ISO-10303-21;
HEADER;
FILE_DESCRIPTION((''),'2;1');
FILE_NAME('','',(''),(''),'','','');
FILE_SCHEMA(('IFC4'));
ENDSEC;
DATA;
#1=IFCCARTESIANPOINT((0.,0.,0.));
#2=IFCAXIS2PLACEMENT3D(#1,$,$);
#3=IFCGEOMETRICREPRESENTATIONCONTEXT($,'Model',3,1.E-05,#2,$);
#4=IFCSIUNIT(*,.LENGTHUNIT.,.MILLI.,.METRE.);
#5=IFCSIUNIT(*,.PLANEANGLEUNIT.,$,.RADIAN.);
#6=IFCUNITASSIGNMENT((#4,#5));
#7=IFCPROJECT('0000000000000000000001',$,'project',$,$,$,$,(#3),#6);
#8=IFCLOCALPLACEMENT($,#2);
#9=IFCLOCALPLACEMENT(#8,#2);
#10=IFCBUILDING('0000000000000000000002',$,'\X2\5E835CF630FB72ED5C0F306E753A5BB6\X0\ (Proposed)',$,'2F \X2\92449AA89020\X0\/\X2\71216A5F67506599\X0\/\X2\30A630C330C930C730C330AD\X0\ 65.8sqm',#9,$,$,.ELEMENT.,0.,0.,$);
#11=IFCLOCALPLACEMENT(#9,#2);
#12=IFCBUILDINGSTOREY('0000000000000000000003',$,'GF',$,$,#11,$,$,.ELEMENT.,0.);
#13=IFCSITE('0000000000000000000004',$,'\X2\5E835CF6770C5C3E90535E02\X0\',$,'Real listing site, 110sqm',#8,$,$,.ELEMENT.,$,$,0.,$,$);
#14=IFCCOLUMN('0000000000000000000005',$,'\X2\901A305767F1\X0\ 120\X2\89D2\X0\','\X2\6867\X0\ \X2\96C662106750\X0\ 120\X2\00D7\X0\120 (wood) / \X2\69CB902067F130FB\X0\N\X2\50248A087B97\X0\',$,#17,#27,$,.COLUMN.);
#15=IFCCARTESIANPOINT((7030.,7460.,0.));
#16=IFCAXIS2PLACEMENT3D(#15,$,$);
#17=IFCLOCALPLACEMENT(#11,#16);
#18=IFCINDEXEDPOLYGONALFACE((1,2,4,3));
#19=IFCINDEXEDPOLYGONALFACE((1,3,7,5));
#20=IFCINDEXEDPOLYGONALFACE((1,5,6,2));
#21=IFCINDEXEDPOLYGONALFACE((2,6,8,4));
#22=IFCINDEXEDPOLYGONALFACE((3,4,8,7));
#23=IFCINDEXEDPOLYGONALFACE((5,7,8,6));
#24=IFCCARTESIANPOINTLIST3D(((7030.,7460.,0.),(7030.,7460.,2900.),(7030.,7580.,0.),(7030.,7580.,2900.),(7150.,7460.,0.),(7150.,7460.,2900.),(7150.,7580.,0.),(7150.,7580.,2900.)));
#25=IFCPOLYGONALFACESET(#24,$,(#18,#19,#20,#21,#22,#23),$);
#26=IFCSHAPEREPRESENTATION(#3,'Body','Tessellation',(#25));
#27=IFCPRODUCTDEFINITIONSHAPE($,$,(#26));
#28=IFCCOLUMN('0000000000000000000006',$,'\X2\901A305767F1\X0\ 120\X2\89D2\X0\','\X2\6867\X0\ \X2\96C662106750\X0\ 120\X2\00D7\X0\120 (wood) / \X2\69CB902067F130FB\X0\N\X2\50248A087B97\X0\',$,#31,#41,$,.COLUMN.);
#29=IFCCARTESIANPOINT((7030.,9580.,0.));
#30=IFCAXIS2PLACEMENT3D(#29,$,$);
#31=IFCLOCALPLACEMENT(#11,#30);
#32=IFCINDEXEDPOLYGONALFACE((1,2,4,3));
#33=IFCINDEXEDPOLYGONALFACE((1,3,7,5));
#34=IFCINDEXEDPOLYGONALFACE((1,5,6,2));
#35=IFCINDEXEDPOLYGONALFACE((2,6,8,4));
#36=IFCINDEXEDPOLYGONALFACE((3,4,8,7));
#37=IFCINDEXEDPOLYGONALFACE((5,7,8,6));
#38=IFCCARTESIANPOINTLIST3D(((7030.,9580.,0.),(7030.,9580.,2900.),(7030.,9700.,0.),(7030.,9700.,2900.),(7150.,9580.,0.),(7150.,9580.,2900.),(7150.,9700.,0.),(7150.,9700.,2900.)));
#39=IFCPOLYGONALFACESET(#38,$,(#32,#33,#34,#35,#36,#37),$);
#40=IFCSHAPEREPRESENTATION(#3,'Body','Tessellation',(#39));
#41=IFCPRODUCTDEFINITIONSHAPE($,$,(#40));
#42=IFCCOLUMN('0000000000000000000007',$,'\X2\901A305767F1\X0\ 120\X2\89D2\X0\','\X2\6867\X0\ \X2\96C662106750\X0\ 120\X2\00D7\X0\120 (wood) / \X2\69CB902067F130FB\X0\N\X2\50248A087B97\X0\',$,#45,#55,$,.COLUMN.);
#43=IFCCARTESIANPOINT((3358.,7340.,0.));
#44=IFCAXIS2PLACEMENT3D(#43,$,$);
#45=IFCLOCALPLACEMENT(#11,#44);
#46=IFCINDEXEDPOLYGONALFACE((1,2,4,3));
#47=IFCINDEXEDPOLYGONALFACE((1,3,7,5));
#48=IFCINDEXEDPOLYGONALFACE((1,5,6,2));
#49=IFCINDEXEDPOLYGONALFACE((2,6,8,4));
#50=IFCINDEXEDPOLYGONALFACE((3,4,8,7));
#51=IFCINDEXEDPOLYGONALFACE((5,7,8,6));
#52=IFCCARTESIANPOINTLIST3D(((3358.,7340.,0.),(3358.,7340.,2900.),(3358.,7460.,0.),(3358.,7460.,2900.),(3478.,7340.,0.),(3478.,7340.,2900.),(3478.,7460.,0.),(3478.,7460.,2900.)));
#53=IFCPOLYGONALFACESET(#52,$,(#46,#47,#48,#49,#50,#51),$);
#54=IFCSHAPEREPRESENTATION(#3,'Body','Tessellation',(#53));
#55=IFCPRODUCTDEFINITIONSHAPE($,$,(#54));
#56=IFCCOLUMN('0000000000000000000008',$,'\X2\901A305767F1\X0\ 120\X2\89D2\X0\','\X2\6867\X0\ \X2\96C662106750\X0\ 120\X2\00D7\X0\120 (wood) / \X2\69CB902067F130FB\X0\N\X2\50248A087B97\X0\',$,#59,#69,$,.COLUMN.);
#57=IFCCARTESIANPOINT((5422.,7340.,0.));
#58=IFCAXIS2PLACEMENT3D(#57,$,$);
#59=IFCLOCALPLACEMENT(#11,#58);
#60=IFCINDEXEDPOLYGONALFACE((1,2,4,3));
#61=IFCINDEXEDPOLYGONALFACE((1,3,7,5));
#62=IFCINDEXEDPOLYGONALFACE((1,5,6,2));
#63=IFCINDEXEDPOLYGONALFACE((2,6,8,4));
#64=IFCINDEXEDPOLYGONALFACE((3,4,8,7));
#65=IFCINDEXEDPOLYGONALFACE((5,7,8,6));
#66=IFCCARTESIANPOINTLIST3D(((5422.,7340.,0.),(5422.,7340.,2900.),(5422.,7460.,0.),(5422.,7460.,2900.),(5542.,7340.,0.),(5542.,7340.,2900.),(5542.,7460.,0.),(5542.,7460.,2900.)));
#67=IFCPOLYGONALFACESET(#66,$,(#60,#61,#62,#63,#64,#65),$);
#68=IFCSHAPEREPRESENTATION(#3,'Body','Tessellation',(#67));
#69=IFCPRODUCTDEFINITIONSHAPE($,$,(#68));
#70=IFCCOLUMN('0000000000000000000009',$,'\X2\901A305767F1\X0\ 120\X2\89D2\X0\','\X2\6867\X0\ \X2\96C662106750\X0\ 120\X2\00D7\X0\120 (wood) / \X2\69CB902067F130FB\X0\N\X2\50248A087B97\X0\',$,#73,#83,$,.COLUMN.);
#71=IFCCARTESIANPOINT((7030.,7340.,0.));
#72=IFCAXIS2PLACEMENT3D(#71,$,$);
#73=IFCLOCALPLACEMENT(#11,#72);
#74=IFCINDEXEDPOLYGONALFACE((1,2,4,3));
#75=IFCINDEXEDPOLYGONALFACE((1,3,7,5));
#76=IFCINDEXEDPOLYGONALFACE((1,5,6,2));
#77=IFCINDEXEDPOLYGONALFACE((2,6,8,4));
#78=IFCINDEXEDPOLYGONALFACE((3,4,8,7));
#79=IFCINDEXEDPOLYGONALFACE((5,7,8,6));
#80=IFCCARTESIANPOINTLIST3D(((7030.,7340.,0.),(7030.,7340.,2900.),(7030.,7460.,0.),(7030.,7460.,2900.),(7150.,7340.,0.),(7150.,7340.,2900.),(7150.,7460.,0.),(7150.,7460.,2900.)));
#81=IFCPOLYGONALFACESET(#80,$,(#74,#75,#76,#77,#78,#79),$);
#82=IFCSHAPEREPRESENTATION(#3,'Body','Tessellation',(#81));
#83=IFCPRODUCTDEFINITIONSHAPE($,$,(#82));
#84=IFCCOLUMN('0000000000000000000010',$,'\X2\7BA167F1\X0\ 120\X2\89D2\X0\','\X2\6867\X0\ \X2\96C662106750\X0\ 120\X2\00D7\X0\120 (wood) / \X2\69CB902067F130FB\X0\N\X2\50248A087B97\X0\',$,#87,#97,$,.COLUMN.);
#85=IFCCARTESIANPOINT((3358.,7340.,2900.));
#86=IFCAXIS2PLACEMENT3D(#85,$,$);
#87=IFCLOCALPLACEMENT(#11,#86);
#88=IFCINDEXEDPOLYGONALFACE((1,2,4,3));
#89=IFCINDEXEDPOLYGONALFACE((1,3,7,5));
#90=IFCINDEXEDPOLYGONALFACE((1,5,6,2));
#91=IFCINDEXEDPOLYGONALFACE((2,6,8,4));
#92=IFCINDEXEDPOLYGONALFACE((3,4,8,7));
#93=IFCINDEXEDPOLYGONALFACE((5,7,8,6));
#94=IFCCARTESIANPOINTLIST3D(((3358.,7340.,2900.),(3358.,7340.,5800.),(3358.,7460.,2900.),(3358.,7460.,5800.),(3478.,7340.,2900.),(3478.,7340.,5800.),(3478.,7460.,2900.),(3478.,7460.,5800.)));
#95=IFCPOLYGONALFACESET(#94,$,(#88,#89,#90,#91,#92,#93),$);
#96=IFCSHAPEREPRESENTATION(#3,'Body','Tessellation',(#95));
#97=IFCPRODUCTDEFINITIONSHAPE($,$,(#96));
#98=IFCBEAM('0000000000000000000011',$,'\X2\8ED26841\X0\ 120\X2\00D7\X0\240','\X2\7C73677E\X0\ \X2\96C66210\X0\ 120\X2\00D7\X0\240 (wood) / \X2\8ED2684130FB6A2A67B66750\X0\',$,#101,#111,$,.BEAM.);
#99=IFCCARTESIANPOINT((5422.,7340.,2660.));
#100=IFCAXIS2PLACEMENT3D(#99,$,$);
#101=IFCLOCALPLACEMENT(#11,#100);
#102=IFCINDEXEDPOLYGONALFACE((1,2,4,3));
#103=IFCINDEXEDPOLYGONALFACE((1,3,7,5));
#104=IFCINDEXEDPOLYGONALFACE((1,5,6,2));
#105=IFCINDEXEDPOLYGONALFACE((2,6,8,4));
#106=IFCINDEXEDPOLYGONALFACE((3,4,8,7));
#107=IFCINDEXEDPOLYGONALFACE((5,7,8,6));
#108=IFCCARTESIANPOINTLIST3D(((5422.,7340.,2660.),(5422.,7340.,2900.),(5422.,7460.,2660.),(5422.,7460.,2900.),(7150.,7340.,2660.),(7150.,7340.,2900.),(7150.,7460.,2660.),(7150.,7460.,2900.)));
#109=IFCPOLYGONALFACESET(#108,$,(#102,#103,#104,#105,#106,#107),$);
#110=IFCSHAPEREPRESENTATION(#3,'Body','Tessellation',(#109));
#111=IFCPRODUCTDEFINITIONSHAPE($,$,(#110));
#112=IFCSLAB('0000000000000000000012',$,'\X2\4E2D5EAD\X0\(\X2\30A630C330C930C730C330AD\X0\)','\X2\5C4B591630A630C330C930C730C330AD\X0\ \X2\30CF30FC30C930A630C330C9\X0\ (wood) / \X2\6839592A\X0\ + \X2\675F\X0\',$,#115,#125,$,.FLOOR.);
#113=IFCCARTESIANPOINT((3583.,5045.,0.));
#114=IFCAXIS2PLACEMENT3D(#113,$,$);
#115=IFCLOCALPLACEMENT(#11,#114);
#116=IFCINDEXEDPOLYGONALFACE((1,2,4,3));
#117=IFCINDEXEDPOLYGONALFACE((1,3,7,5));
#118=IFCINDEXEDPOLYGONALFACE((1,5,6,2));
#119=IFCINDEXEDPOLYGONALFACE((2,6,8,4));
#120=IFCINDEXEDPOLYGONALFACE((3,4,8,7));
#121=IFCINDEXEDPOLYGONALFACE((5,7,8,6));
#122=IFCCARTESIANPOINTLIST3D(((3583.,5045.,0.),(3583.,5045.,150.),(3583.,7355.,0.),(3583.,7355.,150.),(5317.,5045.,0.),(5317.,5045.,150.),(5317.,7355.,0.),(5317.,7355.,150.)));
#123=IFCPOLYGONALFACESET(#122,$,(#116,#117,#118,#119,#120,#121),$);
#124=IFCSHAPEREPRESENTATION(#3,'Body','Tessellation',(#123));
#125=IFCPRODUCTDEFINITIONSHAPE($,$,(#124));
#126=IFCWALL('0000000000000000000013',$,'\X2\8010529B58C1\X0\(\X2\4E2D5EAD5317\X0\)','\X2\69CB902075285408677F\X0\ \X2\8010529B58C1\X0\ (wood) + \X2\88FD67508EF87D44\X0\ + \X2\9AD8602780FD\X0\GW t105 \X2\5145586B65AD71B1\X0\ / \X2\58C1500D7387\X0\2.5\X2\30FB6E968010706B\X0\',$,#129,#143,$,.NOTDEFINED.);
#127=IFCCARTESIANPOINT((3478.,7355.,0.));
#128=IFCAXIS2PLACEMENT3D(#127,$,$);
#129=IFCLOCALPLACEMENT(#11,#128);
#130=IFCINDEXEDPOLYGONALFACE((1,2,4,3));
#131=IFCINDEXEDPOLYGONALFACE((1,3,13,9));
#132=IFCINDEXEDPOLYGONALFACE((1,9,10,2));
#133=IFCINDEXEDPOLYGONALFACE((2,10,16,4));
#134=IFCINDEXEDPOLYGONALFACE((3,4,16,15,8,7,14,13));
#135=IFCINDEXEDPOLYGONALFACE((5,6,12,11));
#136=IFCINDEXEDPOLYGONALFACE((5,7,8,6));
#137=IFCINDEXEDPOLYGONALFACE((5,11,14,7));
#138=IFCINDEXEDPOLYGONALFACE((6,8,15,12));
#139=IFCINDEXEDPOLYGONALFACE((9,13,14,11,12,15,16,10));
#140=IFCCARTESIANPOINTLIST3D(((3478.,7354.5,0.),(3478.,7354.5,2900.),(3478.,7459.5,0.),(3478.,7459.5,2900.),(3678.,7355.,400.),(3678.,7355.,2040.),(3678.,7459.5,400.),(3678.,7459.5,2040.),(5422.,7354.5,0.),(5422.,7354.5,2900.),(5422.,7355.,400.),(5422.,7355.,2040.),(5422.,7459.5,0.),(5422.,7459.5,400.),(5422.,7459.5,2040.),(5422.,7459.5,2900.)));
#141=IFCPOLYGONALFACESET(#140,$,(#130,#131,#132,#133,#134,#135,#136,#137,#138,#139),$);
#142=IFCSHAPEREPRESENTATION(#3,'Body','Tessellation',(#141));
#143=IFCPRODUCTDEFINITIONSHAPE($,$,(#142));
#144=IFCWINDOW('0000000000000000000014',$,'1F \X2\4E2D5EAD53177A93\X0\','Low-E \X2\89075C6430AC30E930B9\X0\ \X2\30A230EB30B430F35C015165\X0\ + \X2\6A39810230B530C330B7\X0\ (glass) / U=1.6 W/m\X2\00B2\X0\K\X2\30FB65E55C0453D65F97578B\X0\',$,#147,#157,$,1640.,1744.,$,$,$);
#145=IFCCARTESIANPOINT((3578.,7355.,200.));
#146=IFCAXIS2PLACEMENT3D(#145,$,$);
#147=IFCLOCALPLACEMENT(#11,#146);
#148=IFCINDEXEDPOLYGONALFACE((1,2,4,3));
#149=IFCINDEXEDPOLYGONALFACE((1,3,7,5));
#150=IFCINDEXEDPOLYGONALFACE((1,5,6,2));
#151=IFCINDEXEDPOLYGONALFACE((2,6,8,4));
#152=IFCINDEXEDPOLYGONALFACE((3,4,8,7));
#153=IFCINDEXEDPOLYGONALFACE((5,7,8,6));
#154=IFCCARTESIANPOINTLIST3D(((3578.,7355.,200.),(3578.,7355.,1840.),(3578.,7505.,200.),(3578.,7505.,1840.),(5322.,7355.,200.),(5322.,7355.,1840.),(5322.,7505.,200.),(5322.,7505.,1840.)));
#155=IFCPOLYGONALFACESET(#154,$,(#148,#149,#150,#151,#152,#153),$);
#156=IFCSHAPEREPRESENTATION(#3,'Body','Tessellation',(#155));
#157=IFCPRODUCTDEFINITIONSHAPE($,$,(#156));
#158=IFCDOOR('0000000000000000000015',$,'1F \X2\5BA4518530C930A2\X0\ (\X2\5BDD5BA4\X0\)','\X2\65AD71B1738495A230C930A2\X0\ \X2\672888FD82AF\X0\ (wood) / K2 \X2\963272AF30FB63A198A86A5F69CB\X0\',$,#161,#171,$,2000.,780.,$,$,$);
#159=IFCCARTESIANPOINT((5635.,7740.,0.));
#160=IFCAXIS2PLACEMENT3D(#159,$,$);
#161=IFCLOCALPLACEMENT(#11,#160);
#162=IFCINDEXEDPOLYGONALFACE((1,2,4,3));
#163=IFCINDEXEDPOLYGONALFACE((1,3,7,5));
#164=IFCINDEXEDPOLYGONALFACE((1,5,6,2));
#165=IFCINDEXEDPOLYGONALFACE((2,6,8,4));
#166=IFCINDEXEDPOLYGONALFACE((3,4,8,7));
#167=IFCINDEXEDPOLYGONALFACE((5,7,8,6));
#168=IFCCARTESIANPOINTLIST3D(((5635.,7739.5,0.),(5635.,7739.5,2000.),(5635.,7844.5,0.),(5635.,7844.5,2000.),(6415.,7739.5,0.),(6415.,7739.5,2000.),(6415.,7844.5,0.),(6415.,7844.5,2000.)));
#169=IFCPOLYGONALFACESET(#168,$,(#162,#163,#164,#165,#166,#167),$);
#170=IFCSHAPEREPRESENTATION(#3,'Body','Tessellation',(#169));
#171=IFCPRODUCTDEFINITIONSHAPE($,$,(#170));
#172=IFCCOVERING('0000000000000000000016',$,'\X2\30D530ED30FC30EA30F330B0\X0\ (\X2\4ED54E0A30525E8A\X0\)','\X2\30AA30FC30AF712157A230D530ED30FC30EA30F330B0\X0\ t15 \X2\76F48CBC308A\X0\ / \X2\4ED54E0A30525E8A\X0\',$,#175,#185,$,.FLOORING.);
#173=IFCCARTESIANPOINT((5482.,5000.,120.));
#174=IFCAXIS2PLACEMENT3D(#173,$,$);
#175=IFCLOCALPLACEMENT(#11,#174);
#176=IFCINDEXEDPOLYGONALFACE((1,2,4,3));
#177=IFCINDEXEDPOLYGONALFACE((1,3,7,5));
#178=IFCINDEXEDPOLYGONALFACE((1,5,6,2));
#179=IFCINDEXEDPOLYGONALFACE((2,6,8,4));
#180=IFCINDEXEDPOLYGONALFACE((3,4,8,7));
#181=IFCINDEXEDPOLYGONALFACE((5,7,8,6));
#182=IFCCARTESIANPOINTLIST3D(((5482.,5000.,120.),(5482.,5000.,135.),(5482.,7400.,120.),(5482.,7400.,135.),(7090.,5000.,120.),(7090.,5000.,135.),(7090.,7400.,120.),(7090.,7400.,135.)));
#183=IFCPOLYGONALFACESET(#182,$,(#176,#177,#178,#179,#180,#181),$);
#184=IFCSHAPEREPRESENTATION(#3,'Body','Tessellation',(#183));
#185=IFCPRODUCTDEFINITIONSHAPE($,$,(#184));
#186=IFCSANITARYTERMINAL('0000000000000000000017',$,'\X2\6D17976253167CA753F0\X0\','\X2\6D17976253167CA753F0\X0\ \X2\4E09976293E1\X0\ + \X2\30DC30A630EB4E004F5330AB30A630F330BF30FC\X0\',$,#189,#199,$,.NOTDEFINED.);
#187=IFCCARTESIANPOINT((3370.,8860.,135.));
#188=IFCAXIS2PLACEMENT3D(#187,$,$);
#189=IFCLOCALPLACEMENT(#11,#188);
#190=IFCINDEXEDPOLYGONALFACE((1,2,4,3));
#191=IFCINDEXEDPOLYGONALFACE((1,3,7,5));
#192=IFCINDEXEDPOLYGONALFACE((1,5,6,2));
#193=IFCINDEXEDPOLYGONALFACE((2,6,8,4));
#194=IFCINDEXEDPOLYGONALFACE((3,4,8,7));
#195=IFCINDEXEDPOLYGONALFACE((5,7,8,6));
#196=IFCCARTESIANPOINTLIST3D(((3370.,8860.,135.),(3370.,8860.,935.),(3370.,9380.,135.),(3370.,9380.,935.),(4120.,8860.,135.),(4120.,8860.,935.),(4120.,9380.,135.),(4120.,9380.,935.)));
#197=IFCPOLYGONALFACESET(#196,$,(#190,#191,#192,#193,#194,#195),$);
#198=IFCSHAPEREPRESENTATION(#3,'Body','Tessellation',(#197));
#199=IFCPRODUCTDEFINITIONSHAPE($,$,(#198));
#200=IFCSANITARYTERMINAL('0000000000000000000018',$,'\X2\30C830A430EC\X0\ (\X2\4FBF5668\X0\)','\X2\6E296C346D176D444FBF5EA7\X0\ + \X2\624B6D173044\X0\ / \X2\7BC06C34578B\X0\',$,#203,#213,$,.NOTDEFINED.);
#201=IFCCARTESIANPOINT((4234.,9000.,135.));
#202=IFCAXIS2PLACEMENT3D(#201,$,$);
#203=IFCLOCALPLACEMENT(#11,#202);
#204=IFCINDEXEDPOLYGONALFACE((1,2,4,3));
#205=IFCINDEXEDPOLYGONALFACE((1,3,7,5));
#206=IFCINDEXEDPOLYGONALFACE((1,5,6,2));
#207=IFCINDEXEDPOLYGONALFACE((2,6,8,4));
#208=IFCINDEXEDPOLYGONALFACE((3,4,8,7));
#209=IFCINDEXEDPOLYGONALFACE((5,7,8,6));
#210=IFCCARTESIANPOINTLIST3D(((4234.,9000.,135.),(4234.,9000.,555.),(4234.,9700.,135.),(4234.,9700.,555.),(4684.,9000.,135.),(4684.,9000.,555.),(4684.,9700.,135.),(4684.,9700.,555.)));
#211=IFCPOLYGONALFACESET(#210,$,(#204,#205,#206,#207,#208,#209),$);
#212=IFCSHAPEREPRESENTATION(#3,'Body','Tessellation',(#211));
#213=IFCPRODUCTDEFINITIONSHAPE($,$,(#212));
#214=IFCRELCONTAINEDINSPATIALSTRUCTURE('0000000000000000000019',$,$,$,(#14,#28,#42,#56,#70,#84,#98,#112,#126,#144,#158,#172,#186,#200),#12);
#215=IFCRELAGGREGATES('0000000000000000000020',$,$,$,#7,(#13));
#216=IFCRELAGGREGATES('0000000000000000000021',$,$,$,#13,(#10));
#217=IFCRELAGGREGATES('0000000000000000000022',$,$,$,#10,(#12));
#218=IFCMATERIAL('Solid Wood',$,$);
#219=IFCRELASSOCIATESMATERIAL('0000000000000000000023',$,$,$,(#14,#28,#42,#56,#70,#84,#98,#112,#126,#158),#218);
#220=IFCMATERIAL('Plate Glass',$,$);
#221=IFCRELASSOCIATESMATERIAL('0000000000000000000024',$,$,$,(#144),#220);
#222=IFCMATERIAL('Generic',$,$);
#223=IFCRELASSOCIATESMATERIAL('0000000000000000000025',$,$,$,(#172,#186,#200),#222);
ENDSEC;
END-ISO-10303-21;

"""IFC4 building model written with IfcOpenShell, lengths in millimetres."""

from ifc_helpers import new_model, si_unit, frame, frame_2d, origin, place, context, project, spatial, rectangle, extrude, material, element, fill, save


model = new_model("IFC4")

# Units and contexts
model_context = context("Model", 3, precision=1e-05, world=origin())
ifc_project = project(units=[si_unit("LENGTHUNIT", "METRE", prefix="MILLI"), si_unit("PLANEANGLEUNIT", "RADIAN")], contexts=[model_context])

# Site, building, storey
site_placement = place(None, origin())
site = spatial("IfcSite", under=ifc_project, at=site_placement, Name="広島県尾道市", ObjectType="Real listing site, 110sqm", CompositionType="ELEMENT", RefElevation=0.0)
building_placement = place(site_placement, origin())
building = spatial("IfcBuilding", under=site, at=building_placement, Name="広島・狭小の町家 (Proposed)", ObjectType="2F 鉄骨造/無機材料/ウッドデッキ 65.8sqm", CompositionType="ELEMENT", ElevationOfRefHeight=0.0, ElevationOfTerrain=0.0)
storey_placement = place(building_placement, origin())
storey = spatial("IfcBuildingStorey", under=building, at=storey_placement, Name="GF", CompositionType="ELEMENT", Elevation=0.0)

# Columns
ifc_material_1 = material(Name="Solid Wood")
column_1_placement = place(storey_placement, frame((7030.0, 7460.0, 0.0)))
element("IfcColumn", 1, at=column_1_placement, inside=storey, material=ifc_material_1, Name="通し柱 120角", Description="桧 集成材 120×120 (wood) / 構造柱・N値計算", PredefinedType="COLUMN", context=model_context, shape_type="SweptSolid", body=[
    extrude(rectangle(XDim=120.0, YDim=120.0, at=frame_2d((60.0, 60.0))), frame((7030.0, 7460.0, 0.0)), (0.0, 0.0, 1.0), 2900.0),
])
column_2_placement = place(storey_placement, frame((7030.0, 9580.0, 0.0)))
element("IfcColumn", 2, at=column_2_placement, inside=storey, material=ifc_material_1, Name="通し柱 120角", Description="桧 集成材 120×120 (wood) / 構造柱・N値計算", PredefinedType="COLUMN", context=model_context, shape_type="SweptSolid", body=[
    extrude(rectangle(XDim=120.0, YDim=120.0, at=frame_2d((60.0, 60.0))), frame((7030.0, 9580.0, 0.0)), (0.0, 0.0, 1.0), 2900.0),
])
column_3_placement = place(storey_placement, frame((3358.0, 7340.0, 0.0)))
element("IfcColumn", 3, at=column_3_placement, inside=storey, material=ifc_material_1, Name="通し柱 120角", Description="桧 集成材 120×120 (wood) / 構造柱・N値計算", PredefinedType="COLUMN", context=model_context, shape_type="SweptSolid", body=[
    extrude(rectangle(XDim=120.0, YDim=120.0, at=frame_2d((60.0, 60.0))), frame((3358.0, 7340.0, 0.0)), (0.0, 0.0, 1.0), 2900.0),
])
column_4_placement = place(storey_placement, frame((5422.0, 7340.0, 0.0)))
element("IfcColumn", 4, at=column_4_placement, inside=storey, material=ifc_material_1, Name="通し柱 120角", Description="桧 集成材 120×120 (wood) / 構造柱・N値計算", PredefinedType="COLUMN", context=model_context, shape_type="SweptSolid", body=[
    extrude(rectangle(XDim=120.0, YDim=120.0, at=frame_2d((60.0, 60.0))), frame((5422.0, 7340.0, 0.0)), (0.0, 0.0, 1.0), 2900.0),
])
column_5_placement = place(storey_placement, frame((7030.0, 7340.0, 0.0)))
element("IfcColumn", 5, at=column_5_placement, inside=storey, material=ifc_material_1, Name="通し柱 120角", Description="桧 集成材 120×120 (wood) / 構造柱・N値計算", PredefinedType="COLUMN", context=model_context, shape_type="SweptSolid", body=[
    extrude(rectangle(XDim=120.0, YDim=120.0, at=frame_2d((60.0, 60.0))), frame((7030.0, 7340.0, 0.0)), (0.0, 0.0, 1.0), 2900.0),
])
column_6_placement = place(storey_placement, frame((3358.0, 7340.0, 2900.0)))
element("IfcColumn", 6, at=column_6_placement, inside=storey, material=ifc_material_1, Name="管柱 120角", Description="桧 集成材 120×120 (wood) / 構造柱・N値計算", PredefinedType="COLUMN", context=model_context, shape_type="SweptSolid", body=[
    extrude(rectangle(XDim=120.0, YDim=120.0, at=frame_2d((60.0, 60.0))), frame((3358.0, 7340.0, 2900.0)), (0.0, 0.0, 1.0), 2900.0),
])

# Beam
beam_1_placement = place(storey_placement, frame((5422.0, 7340.0, 2660.0)))
element("IfcBeam", 7, at=beam_1_placement, inside=storey, material=ifc_material_1, Name="軒桁 120×240", Description="米松 集成 120×240 (wood) / 軒桁・横架材", PredefinedType="BEAM", context=model_context, shape_type="SweptSolid", body=[
    extrude(rectangle(XDim=1728.0, YDim=120.0, at=frame_2d((864.0, 60.0))), frame((5422.0, 7340.0, 2660.0)), (0.0, 0.0, 1.0), 240.0),
])

# Slab
slab_placement = place(storey_placement, frame((3583.0, 5045.0, 0.0)))
element("IfcSlab", 8, at=slab_placement, inside=storey, material=ifc_material_1, Name="中庭(ウッドデッキ)", Description="屋外ウッドデッキ ハードウッド (wood) / 根太 + 束", PredefinedType="FLOOR", context=model_context, shape_type="SweptSolid", body=[
    extrude(rectangle(XDim=1734.0, YDim=2310.0, at=frame_2d((867.0, 1155.0))), frame((3583.0, 5045.0, 0.0)), (0.0, 0.0, 1.0), 150.0),
])

# Wall, opening, window
wall_1_placement = place(storey_placement, frame((3478.0, 7355.0, 0.0)))
wall_1 = element("IfcWall", 9, at=wall_1_placement, inside=storey, material=ifc_material_1, Name="耐力壁(中庭北)", Description="構造用合板 耐力壁 (wood) + 製材軸組 + 高性能GW t105 充填断熱 / 壁倍率2.5・準耐火", PredefinedType="NOTDEFINED", context=model_context, shape_type="SweptSolid", body=[
    extrude(rectangle(XDim=1944.0, YDim=105.0, at=frame_2d((972.0, 52.0))), frame((3478.0, 7355.0, 0.0)), (0.0, 0.0, 1.0), 2900.0),
])
opening_placement = place(storey_placement, frame((3578.0, 7355.0, 200.0)))
opening = element("IfcOpeningElement", 10, at=opening_placement, cuts=wall_1, PredefinedType="NOTDEFINED", context=model_context, shape_type="SweptSolid", body=[
    extrude(rectangle(XDim=1744.0, YDim=150.0, at=frame_2d((872.0, 75.0))), frame((3578.0, 7355.0, 200.0)), (0.0, 0.0, 1.0), 1640.0),
])
ifc_material_2 = material(Name="Plate Glass")
window_placement = place(storey_placement, frame((3578.0, 7355.0, 200.0)))
window = element("IfcWindow", 11, at=window_placement, inside=storey, material=ifc_material_2, Name="1F 中庭北窓", Description="Low-E 複層ガラス アルゴン封入 + 樹脂サッシ (glass) / U=1.6 W/m²K・日射取得型", OverallHeight=1640.0, OverallWidth=1744.0, context=model_context, shape_type="SweptSolid", body=[
    extrude(rectangle(XDim=1744.0, YDim=150.0, at=frame_2d((872.0, 75.0))), frame((3578.0, 7355.0, 200.0)), (0.0, 0.0, 1.0), 1640.0),
])
fill(opening, window)

# Door
door_placement = place(storey_placement, frame((5635.0, 7740.0, 0.0)))
element("IfcDoor", 12, at=door_placement, inside=storey, material=ifc_material_1, Name="1F 室内ドア (寝室)", Description="断熱玄関ドア 木製芯 (wood) / K2 防犯・採風機構", OverallHeight=2000.0, OverallWidth=780.0, context=model_context, shape_type="SweptSolid", body=[
    extrude(rectangle(XDim=780.0, YDim=105.0, at=frame_2d((390.0, 52.0))), frame((5635.0, 7740.0, 0.0)), (0.0, 0.0, 1.0), 2000.0),
])

# Covering
ifc_material_3 = material(Name="Generic")
covering_placement = place(storey_placement, frame((5482.0, 5000.0, 120.0)))
element("IfcCovering", 13, at=covering_placement, inside=storey, material=ifc_material_3, Name="フローリング (仕上げ床)", Description="オーク無垢フローリング t15 直貼り / 仕上げ床", PredefinedType="FLOORING", context=model_context, shape_type="SweptSolid", body=[
    extrude(rectangle(XDim=1608.0, YDim=2400.0, at=frame_2d((804.0, 1200.0))), frame((5482.0, 5000.0, 120.0)), (0.0, 0.0, 1.0), 15.0),
])

# Sanitary terminals
sanitary_terminal_1_placement = place(storey_placement, frame((3370.0, 8860.0, 135.0)))
element("IfcSanitaryTerminal", 14, at=sanitary_terminal_1_placement, inside=storey, material=ifc_material_3, Name="洗面化粧台", Description="洗面化粧台 三面鏡 + ボウル一体カウンター", PredefinedType="NOTDEFINED", context=model_context, shape_type="SweptSolid", body=[
    extrude(rectangle(XDim=750.0, YDim=520.0, at=frame_2d((375.0, 260.0))), frame((3370.0, 8860.0, 135.0)), (0.0, 0.0, 1.0), 800.0),
])
sanitary_terminal_2_placement = place(storey_placement, frame((4234.0, 9000.0, 135.0)))
element("IfcSanitaryTerminal", 15, at=sanitary_terminal_2_placement, inside=storey, material=ifc_material_3, Name="トイレ (便器)", Description="温水洗浄便座 + 手洗い / 節水型", PredefinedType="NOTDEFINED", context=model_context, shape_type="SweptSolid", body=[
    extrude(rectangle(XDim=450.0, YDim=700.0, at=frame_2d((225.0, 350.0))), frame((4234.0, 9000.0, 135.0)), (0.0, 0.0, 1.0), 420.0),
])

save(model, "model.ifc")
